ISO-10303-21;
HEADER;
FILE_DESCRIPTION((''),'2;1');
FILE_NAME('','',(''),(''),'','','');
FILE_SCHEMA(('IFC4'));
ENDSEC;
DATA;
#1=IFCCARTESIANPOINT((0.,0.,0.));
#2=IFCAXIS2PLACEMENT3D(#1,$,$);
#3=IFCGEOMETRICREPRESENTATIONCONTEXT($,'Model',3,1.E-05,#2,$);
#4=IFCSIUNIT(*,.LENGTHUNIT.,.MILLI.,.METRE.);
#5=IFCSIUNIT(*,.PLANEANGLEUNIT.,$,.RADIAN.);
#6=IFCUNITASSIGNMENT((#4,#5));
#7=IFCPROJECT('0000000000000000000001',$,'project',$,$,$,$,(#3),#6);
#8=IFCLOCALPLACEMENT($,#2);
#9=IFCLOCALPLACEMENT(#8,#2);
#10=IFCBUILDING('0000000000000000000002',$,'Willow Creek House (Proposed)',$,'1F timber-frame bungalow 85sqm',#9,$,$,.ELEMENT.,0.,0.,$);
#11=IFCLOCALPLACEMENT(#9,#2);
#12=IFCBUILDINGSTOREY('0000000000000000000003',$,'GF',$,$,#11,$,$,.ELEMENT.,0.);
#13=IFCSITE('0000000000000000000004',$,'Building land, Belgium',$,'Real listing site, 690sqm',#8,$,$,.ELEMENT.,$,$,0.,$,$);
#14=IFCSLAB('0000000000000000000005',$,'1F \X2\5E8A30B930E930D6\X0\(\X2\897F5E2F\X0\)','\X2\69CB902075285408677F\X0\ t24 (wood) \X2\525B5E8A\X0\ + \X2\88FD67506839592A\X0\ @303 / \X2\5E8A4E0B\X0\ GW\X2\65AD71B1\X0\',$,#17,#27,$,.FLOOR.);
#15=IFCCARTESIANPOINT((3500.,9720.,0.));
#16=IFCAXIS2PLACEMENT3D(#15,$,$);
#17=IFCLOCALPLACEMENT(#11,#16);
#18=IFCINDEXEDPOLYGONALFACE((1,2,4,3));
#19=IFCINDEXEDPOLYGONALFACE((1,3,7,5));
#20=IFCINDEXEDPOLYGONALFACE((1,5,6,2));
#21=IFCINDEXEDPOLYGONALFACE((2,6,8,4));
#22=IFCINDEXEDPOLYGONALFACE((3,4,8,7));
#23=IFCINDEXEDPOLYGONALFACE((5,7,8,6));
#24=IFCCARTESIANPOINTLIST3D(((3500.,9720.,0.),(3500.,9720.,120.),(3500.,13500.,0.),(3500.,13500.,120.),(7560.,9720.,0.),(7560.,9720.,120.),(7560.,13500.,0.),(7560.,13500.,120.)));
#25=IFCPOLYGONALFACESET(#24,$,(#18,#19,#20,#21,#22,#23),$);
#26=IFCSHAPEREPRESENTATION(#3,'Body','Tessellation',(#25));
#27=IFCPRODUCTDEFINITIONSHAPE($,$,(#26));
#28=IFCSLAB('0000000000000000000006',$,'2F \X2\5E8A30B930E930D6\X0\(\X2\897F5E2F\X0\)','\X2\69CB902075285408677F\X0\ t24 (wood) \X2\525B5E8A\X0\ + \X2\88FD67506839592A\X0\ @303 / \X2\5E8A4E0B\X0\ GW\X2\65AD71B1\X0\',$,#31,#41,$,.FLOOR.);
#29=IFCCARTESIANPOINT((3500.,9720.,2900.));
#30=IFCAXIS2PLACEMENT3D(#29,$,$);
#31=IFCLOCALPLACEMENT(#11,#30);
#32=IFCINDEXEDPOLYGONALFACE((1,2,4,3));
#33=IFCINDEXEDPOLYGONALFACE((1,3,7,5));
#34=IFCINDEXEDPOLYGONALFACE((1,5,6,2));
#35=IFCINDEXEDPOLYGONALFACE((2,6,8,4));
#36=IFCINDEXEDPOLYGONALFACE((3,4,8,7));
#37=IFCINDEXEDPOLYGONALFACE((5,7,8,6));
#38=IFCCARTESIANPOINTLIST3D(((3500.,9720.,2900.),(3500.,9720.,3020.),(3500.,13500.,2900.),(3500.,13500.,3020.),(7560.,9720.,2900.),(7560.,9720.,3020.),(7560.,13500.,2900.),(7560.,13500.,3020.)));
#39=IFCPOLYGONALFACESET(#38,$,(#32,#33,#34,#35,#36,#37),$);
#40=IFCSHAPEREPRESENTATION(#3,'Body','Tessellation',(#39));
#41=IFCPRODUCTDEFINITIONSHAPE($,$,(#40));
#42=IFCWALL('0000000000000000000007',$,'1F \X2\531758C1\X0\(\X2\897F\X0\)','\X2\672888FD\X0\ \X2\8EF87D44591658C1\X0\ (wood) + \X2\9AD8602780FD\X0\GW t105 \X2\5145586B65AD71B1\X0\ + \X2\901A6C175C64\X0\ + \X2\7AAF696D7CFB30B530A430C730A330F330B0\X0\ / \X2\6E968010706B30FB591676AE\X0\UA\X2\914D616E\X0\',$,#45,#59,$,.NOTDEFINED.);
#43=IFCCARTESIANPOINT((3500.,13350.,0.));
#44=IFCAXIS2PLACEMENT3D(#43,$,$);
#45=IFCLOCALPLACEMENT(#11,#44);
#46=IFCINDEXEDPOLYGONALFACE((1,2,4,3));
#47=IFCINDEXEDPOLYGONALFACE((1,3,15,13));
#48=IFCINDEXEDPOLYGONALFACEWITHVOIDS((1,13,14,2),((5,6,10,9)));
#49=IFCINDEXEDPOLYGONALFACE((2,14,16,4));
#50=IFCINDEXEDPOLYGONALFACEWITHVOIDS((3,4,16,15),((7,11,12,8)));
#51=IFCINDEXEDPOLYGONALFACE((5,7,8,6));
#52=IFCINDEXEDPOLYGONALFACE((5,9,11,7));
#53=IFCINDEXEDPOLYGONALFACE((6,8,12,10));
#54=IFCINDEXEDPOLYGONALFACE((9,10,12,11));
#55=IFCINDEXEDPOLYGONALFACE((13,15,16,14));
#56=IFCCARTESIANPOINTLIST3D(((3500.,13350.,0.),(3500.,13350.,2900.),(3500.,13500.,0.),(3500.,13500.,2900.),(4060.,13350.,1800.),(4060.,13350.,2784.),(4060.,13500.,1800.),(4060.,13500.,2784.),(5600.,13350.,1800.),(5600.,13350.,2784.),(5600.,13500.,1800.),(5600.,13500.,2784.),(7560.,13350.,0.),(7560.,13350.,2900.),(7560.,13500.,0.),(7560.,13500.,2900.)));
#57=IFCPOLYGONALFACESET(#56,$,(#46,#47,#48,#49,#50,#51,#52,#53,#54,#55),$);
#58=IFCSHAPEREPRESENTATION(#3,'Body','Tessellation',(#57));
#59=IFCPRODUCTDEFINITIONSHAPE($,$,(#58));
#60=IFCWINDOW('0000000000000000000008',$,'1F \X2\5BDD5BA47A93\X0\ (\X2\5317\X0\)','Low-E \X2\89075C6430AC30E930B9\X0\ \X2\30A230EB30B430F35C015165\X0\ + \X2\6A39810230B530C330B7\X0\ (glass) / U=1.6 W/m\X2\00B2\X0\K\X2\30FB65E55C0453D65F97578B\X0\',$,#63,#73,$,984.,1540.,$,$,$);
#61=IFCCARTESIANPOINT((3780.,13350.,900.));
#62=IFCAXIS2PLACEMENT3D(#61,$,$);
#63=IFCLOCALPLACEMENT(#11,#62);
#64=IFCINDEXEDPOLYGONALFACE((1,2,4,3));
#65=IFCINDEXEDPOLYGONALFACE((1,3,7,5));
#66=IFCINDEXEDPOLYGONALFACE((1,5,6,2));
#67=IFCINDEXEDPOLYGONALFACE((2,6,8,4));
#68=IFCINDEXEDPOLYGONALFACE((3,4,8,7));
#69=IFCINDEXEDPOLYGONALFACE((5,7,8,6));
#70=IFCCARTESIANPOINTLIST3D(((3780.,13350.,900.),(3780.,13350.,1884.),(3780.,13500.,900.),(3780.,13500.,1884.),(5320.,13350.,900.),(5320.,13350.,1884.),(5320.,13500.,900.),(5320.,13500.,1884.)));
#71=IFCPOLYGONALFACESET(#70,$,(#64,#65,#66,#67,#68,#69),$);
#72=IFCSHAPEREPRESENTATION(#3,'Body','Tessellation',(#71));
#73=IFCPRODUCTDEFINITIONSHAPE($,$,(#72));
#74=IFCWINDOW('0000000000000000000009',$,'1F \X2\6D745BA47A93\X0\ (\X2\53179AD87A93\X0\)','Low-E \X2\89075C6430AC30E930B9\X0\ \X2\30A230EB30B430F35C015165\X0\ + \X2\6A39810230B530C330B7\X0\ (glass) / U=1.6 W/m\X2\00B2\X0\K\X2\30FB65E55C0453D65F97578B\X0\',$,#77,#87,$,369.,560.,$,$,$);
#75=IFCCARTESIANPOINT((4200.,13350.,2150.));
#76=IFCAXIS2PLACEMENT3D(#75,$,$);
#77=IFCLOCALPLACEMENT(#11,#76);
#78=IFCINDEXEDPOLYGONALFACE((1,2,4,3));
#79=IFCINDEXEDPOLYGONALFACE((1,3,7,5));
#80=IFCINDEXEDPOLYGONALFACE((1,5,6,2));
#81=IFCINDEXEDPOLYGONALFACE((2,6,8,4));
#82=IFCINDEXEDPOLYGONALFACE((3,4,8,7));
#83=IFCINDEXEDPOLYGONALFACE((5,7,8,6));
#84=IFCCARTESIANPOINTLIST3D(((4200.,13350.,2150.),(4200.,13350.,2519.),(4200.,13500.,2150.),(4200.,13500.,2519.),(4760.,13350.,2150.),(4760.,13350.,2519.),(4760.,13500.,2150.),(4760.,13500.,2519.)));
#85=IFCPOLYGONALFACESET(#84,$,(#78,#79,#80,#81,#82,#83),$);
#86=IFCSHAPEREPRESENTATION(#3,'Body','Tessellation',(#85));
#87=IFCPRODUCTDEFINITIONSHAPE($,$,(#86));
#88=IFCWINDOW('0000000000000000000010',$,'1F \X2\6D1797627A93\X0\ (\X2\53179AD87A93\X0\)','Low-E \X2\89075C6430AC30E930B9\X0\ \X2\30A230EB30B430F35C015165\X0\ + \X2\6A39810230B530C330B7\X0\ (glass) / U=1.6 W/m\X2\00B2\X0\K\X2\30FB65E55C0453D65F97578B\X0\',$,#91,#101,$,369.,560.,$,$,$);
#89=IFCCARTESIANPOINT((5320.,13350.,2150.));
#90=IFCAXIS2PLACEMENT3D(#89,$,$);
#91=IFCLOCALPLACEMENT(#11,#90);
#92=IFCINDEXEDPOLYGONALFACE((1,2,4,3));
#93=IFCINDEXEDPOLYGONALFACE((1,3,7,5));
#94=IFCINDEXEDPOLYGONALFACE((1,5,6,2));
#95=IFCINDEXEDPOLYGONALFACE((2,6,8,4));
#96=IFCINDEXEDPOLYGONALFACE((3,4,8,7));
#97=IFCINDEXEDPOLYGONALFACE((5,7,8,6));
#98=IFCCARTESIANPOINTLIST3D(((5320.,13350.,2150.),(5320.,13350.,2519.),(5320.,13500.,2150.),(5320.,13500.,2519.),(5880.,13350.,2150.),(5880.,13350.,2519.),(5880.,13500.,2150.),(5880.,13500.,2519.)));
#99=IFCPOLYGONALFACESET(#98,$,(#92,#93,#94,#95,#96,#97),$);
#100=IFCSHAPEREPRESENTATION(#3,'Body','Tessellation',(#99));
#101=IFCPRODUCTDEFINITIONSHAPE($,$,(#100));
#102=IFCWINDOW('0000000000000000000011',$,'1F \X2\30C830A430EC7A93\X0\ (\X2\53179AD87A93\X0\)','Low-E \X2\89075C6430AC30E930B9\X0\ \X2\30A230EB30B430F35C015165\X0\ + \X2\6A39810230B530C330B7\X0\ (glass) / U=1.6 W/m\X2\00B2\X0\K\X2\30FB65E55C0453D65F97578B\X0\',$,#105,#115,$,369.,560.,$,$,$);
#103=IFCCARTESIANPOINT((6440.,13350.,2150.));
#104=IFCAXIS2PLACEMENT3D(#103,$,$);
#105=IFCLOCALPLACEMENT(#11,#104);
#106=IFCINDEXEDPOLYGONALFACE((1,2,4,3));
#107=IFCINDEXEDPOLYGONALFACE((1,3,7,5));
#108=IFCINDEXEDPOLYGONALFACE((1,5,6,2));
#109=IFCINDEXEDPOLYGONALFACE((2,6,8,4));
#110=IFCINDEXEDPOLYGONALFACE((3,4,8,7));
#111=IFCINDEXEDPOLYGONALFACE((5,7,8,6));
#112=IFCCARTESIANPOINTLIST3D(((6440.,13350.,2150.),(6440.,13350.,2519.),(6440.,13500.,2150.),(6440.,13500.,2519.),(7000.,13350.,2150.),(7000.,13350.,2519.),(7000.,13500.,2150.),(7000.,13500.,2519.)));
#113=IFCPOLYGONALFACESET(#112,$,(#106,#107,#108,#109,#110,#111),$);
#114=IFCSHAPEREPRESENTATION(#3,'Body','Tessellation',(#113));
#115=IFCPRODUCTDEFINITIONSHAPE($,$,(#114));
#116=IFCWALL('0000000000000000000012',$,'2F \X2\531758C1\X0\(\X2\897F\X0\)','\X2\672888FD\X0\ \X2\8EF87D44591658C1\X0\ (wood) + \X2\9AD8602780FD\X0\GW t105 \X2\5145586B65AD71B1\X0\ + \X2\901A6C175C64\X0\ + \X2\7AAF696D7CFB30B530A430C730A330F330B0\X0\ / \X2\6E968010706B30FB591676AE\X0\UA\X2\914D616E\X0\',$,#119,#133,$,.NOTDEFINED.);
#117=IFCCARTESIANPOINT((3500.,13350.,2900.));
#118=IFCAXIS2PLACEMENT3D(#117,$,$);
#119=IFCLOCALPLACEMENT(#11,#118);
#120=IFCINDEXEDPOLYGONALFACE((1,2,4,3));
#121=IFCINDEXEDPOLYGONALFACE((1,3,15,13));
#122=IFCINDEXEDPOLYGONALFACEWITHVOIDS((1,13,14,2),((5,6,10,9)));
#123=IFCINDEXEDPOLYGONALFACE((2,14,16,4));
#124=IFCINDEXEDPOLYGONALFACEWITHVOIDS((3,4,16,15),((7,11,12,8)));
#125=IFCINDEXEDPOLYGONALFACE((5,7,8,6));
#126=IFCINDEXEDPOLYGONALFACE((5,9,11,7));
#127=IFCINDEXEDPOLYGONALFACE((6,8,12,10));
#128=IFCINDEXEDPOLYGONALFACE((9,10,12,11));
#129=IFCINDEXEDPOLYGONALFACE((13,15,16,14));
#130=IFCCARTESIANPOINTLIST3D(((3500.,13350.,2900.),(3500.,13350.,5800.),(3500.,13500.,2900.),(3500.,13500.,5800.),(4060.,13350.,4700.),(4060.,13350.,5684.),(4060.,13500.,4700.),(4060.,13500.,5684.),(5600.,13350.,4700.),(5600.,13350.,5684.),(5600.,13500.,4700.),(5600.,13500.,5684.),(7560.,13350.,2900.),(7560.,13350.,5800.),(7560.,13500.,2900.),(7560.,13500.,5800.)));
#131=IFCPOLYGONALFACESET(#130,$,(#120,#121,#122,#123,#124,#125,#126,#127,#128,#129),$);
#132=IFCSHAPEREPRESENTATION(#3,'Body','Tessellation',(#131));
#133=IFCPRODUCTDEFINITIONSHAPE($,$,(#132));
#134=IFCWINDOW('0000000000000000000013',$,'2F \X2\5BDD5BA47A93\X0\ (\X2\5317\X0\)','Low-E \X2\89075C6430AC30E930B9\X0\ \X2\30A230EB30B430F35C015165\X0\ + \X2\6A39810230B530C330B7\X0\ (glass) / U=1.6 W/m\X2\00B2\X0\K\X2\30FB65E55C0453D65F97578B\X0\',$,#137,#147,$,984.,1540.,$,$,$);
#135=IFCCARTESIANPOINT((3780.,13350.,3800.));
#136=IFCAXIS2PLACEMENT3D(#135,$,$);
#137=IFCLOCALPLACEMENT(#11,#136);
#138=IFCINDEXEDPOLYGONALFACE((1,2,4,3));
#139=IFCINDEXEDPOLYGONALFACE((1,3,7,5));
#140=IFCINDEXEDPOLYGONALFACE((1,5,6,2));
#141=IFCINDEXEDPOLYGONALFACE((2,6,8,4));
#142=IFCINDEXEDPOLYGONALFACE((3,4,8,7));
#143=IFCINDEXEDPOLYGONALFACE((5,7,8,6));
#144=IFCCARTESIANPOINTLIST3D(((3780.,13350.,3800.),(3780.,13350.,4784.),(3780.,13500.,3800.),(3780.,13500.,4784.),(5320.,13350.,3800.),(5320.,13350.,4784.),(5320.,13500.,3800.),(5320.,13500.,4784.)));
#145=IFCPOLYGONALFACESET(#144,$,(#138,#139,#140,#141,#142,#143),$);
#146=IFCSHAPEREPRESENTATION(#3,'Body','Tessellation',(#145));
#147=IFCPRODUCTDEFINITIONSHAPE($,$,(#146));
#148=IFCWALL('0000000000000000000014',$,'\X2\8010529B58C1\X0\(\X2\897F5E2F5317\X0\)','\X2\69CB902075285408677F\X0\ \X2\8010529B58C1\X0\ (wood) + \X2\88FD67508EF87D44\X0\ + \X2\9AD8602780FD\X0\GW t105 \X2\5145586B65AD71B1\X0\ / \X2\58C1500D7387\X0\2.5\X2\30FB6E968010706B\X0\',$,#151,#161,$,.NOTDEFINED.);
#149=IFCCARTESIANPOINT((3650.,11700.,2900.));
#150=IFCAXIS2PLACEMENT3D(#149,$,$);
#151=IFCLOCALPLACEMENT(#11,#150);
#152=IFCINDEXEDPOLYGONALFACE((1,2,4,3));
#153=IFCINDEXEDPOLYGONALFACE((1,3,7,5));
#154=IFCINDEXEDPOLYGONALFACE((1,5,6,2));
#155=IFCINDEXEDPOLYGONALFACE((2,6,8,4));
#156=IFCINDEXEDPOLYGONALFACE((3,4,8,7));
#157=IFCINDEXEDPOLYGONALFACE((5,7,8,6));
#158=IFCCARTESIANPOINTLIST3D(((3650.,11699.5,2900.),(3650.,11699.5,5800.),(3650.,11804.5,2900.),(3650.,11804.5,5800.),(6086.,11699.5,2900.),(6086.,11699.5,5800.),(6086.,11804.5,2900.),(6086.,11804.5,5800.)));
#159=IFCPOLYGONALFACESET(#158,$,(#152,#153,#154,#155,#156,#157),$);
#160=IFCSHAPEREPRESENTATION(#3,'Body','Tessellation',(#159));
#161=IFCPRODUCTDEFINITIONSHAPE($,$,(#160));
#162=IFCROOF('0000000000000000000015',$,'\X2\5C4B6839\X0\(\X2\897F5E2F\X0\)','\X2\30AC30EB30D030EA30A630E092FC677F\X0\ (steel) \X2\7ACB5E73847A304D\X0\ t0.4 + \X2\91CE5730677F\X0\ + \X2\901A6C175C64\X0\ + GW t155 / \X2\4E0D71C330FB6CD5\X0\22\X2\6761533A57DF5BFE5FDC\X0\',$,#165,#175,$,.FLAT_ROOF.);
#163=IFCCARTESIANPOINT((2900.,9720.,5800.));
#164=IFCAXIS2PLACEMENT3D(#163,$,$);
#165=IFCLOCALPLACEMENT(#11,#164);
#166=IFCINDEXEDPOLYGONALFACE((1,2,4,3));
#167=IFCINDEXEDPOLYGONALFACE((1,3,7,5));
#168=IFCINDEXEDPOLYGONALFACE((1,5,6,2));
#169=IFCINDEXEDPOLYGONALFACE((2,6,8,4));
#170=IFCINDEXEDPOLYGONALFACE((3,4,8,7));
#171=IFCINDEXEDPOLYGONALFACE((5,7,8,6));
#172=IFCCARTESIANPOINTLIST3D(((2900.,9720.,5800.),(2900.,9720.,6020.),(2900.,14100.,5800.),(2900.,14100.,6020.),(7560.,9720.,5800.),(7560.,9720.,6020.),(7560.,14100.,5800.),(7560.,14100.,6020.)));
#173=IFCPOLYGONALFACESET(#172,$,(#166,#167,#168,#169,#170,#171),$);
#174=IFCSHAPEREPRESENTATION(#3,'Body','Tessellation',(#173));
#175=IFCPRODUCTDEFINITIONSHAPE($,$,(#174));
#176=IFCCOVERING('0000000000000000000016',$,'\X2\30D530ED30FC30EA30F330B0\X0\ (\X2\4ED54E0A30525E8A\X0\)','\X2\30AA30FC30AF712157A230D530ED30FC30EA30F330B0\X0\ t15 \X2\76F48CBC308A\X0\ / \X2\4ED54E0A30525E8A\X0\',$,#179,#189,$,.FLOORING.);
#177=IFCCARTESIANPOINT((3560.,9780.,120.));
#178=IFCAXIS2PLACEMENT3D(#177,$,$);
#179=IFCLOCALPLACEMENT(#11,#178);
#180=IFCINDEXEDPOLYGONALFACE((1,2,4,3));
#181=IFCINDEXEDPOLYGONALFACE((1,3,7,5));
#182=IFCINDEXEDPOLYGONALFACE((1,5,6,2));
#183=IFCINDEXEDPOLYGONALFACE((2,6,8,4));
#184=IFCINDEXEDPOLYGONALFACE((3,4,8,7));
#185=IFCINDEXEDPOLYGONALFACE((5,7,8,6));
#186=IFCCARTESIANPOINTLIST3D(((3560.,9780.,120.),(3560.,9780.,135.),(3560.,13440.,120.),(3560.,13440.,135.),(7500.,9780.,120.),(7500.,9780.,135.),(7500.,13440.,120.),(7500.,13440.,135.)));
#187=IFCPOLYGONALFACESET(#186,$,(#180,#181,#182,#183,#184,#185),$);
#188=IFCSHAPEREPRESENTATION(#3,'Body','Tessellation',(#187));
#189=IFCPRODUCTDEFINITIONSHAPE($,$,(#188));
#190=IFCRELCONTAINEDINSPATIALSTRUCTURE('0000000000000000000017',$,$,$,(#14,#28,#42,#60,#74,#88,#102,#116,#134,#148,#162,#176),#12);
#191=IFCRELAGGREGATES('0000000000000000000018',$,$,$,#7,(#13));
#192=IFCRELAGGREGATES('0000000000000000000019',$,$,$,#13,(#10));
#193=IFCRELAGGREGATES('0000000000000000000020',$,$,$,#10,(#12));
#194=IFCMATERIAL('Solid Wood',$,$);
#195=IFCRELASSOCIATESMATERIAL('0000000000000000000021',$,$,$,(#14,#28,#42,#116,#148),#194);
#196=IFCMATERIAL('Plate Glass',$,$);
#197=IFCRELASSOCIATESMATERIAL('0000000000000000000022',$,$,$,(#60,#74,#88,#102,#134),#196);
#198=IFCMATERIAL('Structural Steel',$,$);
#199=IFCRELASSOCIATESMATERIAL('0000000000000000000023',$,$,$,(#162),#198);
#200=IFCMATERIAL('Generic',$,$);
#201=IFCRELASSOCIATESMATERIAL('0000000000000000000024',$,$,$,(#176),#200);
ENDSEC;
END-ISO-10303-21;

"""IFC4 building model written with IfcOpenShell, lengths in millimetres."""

from ifc_helpers import new_model, si_unit, frame, frame_2d, origin, place, context, project, spatial, rectangle, extrude, material, element, fill, save


model = new_model("IFC4")

# Units and contexts
model_context = context("Model", 3, precision=1e-05, world=origin())
ifc_project = project(units=[si_unit("LENGTHUNIT", "METRE", prefix="MILLI"), si_unit("PLANEANGLEUNIT", "RADIAN")], contexts=[model_context])

# Site, building, storey
site_placement = place(None, origin())
site = spatial("IfcSite", under=ifc_project, at=site_placement, Name="Building land, Belgium", ObjectType="Real listing site, 690sqm", CompositionType="ELEMENT", RefElevation=0.0)
building_placement = place(site_placement, origin())
building = spatial("IfcBuilding", under=site, at=building_placement, Name="Willow Creek House (Proposed)", ObjectType="1F timber-frame bungalow 85sqm", CompositionType="ELEMENT", ElevationOfRefHeight=0.0, ElevationOfTerrain=0.0)
storey_placement = place(building_placement, origin())
storey = spatial("IfcBuildingStorey", under=building, at=storey_placement, Name="GF", CompositionType="ELEMENT", Elevation=0.0)

# Slabs
ifc_material_1 = material(Name="Solid Wood")
slab_1_placement = place(storey_placement, frame((3500.0, 9720.0, 0.0)))
element("IfcSlab", 1, at=slab_1_placement, inside=storey, material=ifc_material_1, Name="1F 床スラブ(西帯)", Description="構造用合板 t24 (wood) 剛床 + 製材根太 @303 / 床下 GW断熱", PredefinedType="FLOOR", context=model_context, shape_type="SweptSolid", body=[
    extrude(rectangle(XDim=4060.0, YDim=3780.0, at=frame_2d((2030.0, 1890.0))), frame((3500.0, 9720.0, 0.0)), (0.0, 0.0, 1.0), 120.0),
])
slab_2_placement = place(storey_placement, frame((3500.0, 9720.0, 2900.0)))
element("IfcSlab", 2, at=slab_2_placement, inside=storey, material=ifc_material_1, Name="2F 床スラブ(西帯)", Description="構造用合板 t24 (wood) 剛床 + 製材根太 @303 / 床下 GW断熱", PredefinedType="FLOOR", context=model_context, shape_type="SweptSolid", body=[
    extrude(rectangle(XDim=4060.0, YDim=3780.0, at=frame_2d((2030.0, 1890.0))), frame((3500.0, 9720.0, 2900.0)), (0.0, 0.0, 1.0), 120.0),
])

# Wall, openings, windows
wall_1_placement = place(storey_placement, frame((3500.0, 13350.0, 0.0)))
wall_1 = element("IfcWall", 3, at=wall_1_placement, inside=storey, material=ifc_material_1, Name="1F 北壁(西)", Description="木製 軸組外壁 (wood) + 高性能GW t105 充填断熱 + 通気層 + 窯業系サイディング / 準耐火・外皮UA配慮", PredefinedType="NOTDEFINED", context=model_context, shape_type="SweptSolid", body=[
    extrude(rectangle(XDim=4060.0, YDim=150.0, at=frame_2d((2030.0, 75.0))), frame((3500.0, 13350.0, 0.0)), (0.0, 0.0, 1.0), 2900.0),
])
opening_1_placement = place(storey_placement, frame((3780.0, 13350.0, 900.0)))
opening_1 = element("IfcOpeningElement", 4, at=opening_1_placement, cuts=wall_1, PredefinedType="NOTDEFINED", context=model_context, shape_type="SweptSolid", body=[
    extrude(rectangle(XDim=1540.0, YDim=150.0, at=frame_2d((770.0, 75.0))), frame((3780.0, 13350.0, 900.0)), (0.0, 0.0, 1.0), 984.0),
])
opening_2_placement = place(storey_placement, frame((4200.0, 13350.0, 2150.0)))
opening_2 = element("IfcOpeningElement", 5, at=opening_2_placement, cuts=wall_1, PredefinedType="NOTDEFINED", context=model_context, shape_type="SweptSolid", body=[
    extrude(rectangle(XDim=560.0, YDim=150.0, at=frame_2d((280.0, 75.0))), frame((4200.0, 13350.0, 2150.0)), (0.0, 0.0, 1.0), 369.0),
])
opening_3_placement = place(storey_placement, frame((5320.0, 13350.0, 2150.0)))
opening_3 = element("IfcOpeningElement", 6, at=opening_3_placement, cuts=wall_1, PredefinedType="NOTDEFINED", context=model_context, shape_type="SweptSolid", body=[
    extrude(rectangle(XDim=560.0, YDim=150.0, at=frame_2d((280.0, 75.0))), frame((5320.0, 13350.0, 2150.0)), (0.0, 0.0, 1.0), 369.0),
])
opening_4_placement = place(storey_placement, frame((6440.0, 13350.0, 2150.0)))
opening_4 = element("IfcOpeningElement", 7, at=opening_4_placement, cuts=wall_1, PredefinedType="NOTDEFINED", context=model_context, shape_type="SweptSolid", body=[
    extrude(rectangle(XDim=560.0, YDim=150.0, at=frame_2d((280.0, 75.0))), frame((6440.0, 13350.0, 2150.0)), (0.0, 0.0, 1.0), 369.0),
])
ifc_material_2 = material(Name="Plate Glass")
window_1_placement = place(storey_placement, frame((3780.0, 13350.0, 900.0)))
window_1 = element("IfcWindow", 8, at=window_1_placement, inside=storey, material=ifc_material_2, Name="1F 寝室窓 (北)", Description="Low-E 複層ガラス アルゴン封入 + 樹脂サッシ (glass) / U=1.6 W/m²K・日射取得型", OverallHeight=984.0, OverallWidth=1540.0, context=model_context, shape_type="SweptSolid", body=[
    extrude(rectangle(XDim=1540.0, YDim=150.0, at=frame_2d((770.0, 75.0))), frame((3780.0, 13350.0, 900.0)), (0.0, 0.0, 1.0), 984.0),
])
fill(opening_1, window_1)
window_2_placement = place(storey_placement, frame((4200.0, 13350.0, 2150.0)))
window_2 = element("IfcWindow", 9, at=window_2_placement, inside=storey, material=ifc_material_2, Name="1F 浴室窓 (北高窓)", Description="Low-E 複層ガラス アルゴン封入 + 樹脂サッシ (glass) / U=1.6 W/m²K・日射取得型", OverallHeight=369.0, OverallWidth=560.0, context=model_context, shape_type="SweptSolid", body=[
    extrude(rectangle(XDim=560.0, YDim=150.0, at=frame_2d((280.0, 75.0))), frame((4200.0, 13350.0, 2150.0)), (0.0, 0.0, 1.0), 369.0),
])
fill(opening_2, window_2)
window_3_placement = place(storey_placement, frame((5320.0, 13350.0, 2150.0)))
window_3 = element("IfcWindow", 10, at=window_3_placement, inside=storey, material=ifc_material_2, Name="1F 洗面窓 (北高窓)", Description="Low-E 複層ガラス アルゴン封入 + 樹脂サッシ (glass) / U=1.6 W/m²K・日射取得型", OverallHeight=369.0, OverallWidth=560.0, context=model_context, shape_type="SweptSolid", body=[
    extrude(rectangle(XDim=560.0, YDim=150.0, at=frame_2d((280.0, 75.0))), frame((5320.0, 13350.0, 2150.0)), (0.0, 0.0, 1.0), 369.0),
])
fill(opening_3, window_3)
window_4_placement = place(storey_placement, frame((6440.0, 13350.0, 2150.0)))
window_4 = element("IfcWindow", 11, at=window_4_placement, inside=storey, material=ifc_material_2, Name="1F トイレ窓 (北高窓)", Description="Low-E 複層ガラス アルゴン封入 + 樹脂サッシ (glass) / U=1.6 W/m²K・日射取得型", OverallHeight=369.0, OverallWidth=560.0, context=model_context, shape_type="SweptSolid", body=[
    extrude(rectangle(XDim=560.0, YDim=150.0, at=frame_2d((280.0, 75.0))), frame((6440.0, 13350.0, 2150.0)), (0.0, 0.0, 1.0), 369.0),
])
fill(opening_4, window_4)

# Wall, opening, window
wall_2_placement = place(storey_placement, frame((3500.0, 13350.0, 2900.0)))
wall_2 = element("IfcWall", 12, at=wall_2_placement, inside=storey, material=ifc_material_1, Name="2F 北壁(西)", Description="木製 軸組外壁 (wood) + 高性能GW t105 充填断熱 + 通気層 + 窯業系サイディング / 準耐火・外皮UA配慮", PredefinedType="NOTDEFINED", context=model_context, shape_type="SweptSolid", body=[
    extrude(rectangle(XDim=4060.0, YDim=150.0, at=frame_2d((2030.0, 75.0))), frame((3500.0, 13350.0, 2900.0)), (0.0, 0.0, 1.0), 2900.0),
])
opening_5_placement = place(storey_placement, frame((3780.0, 13350.0, 3800.0)))
opening_5 = element("IfcOpeningElement", 13, at=opening_5_placement, cuts=wall_2, PredefinedType="NOTDEFINED", context=model_context, shape_type="SweptSolid", body=[
    extrude(rectangle(XDim=1540.0, YDim=150.0, at=frame_2d((770.0, 75.0))), frame((3780.0, 13350.0, 3800.0)), (0.0, 0.0, 1.0), 984.0),
])
window_5_placement = place(storey_placement, frame((3780.0, 13350.0, 3800.0)))
window_5 = element("IfcWindow", 14, at=window_5_placement, inside=storey, material=ifc_material_2, Name="2F 寝室窓 (北)", Description="Low-E 複層ガラス アルゴン封入 + 樹脂サッシ (glass) / U=1.6 W/m²K・日射取得型", OverallHeight=984.0, OverallWidth=1540.0, context=model_context, shape_type="SweptSolid", body=[
    extrude(rectangle(XDim=1540.0, YDim=150.0, at=frame_2d((770.0, 75.0))), frame((3780.0, 13350.0, 3800.0)), (0.0, 0.0, 1.0), 984.0),
])
fill(opening_5, window_5)

# Wall
wall_3_placement = place(storey_placement, frame((3650.0, 11700.0, 2900.0)))
element("IfcWall", 15, at=wall_3_placement, inside=storey, material=ifc_material_1, Name="耐力壁(西帯北)", Description="構造用合板 耐力壁 (wood) + 製材軸組 + 高性能GW t105 充填断熱 / 壁倍率2.5・準耐火", PredefinedType="NOTDEFINED", context=model_context, shape_type="SweptSolid", body=[
    extrude(rectangle(XDim=2436.0, YDim=105.0, at=frame_2d((1218.0, 52.0))), frame((3650.0, 11700.0, 2900.0)), (0.0, 0.0, 1.0), 2900.0),
])

# Roof
ifc_material_3 = material(Name="Structural Steel")
for number, where, name in (
    (16, (2900.0, 9720.0, 5800.0), "屋根(西帯)"),
):
    element("IfcRoof", number, at=place(storey_placement, frame(where)), inside=storey, material=ifc_material_3, Name=name, Description="ガルバリウム鋼板 (steel) 立平葺き t0.4 + 野地板 + 通気層 + GW t155 / 不燃・法22条区域対応", PredefinedType="FLAT_ROOF", context=model_context, shape_type="SweptSolid", body=[
        extrude(rectangle(XDim=4660.0, YDim=4380.0, at=frame_2d((2330.0, 2190.0))), frame((2900.0, 9720.0, 5800.0)), (0.0, 0.0, 1.0), 220.0),
    ])

# Covering
ifc_material_4 = material(Name="Generic")
covering_1_placement = place(storey_placement, frame((3560.0, 9780.0, 120.0)))
element("IfcCovering", 17, at=covering_1_placement, inside=storey, material=ifc_material_4, Name="フローリング (仕上げ床)", Description="オーク無垢フローリング t15 直貼り / 仕上げ床", PredefinedType="FLOORING", context=model_context, shape_type="SweptSolid", body=[
    extrude(rectangle(XDim=3940.0, YDim=3660.0, at=frame_2d((1970.0, 1830.0))), frame((3560.0, 9780.0, 120.0)), (0.0, 0.0, 1.0), 15.0),
])

save(model, "model.ifc")
